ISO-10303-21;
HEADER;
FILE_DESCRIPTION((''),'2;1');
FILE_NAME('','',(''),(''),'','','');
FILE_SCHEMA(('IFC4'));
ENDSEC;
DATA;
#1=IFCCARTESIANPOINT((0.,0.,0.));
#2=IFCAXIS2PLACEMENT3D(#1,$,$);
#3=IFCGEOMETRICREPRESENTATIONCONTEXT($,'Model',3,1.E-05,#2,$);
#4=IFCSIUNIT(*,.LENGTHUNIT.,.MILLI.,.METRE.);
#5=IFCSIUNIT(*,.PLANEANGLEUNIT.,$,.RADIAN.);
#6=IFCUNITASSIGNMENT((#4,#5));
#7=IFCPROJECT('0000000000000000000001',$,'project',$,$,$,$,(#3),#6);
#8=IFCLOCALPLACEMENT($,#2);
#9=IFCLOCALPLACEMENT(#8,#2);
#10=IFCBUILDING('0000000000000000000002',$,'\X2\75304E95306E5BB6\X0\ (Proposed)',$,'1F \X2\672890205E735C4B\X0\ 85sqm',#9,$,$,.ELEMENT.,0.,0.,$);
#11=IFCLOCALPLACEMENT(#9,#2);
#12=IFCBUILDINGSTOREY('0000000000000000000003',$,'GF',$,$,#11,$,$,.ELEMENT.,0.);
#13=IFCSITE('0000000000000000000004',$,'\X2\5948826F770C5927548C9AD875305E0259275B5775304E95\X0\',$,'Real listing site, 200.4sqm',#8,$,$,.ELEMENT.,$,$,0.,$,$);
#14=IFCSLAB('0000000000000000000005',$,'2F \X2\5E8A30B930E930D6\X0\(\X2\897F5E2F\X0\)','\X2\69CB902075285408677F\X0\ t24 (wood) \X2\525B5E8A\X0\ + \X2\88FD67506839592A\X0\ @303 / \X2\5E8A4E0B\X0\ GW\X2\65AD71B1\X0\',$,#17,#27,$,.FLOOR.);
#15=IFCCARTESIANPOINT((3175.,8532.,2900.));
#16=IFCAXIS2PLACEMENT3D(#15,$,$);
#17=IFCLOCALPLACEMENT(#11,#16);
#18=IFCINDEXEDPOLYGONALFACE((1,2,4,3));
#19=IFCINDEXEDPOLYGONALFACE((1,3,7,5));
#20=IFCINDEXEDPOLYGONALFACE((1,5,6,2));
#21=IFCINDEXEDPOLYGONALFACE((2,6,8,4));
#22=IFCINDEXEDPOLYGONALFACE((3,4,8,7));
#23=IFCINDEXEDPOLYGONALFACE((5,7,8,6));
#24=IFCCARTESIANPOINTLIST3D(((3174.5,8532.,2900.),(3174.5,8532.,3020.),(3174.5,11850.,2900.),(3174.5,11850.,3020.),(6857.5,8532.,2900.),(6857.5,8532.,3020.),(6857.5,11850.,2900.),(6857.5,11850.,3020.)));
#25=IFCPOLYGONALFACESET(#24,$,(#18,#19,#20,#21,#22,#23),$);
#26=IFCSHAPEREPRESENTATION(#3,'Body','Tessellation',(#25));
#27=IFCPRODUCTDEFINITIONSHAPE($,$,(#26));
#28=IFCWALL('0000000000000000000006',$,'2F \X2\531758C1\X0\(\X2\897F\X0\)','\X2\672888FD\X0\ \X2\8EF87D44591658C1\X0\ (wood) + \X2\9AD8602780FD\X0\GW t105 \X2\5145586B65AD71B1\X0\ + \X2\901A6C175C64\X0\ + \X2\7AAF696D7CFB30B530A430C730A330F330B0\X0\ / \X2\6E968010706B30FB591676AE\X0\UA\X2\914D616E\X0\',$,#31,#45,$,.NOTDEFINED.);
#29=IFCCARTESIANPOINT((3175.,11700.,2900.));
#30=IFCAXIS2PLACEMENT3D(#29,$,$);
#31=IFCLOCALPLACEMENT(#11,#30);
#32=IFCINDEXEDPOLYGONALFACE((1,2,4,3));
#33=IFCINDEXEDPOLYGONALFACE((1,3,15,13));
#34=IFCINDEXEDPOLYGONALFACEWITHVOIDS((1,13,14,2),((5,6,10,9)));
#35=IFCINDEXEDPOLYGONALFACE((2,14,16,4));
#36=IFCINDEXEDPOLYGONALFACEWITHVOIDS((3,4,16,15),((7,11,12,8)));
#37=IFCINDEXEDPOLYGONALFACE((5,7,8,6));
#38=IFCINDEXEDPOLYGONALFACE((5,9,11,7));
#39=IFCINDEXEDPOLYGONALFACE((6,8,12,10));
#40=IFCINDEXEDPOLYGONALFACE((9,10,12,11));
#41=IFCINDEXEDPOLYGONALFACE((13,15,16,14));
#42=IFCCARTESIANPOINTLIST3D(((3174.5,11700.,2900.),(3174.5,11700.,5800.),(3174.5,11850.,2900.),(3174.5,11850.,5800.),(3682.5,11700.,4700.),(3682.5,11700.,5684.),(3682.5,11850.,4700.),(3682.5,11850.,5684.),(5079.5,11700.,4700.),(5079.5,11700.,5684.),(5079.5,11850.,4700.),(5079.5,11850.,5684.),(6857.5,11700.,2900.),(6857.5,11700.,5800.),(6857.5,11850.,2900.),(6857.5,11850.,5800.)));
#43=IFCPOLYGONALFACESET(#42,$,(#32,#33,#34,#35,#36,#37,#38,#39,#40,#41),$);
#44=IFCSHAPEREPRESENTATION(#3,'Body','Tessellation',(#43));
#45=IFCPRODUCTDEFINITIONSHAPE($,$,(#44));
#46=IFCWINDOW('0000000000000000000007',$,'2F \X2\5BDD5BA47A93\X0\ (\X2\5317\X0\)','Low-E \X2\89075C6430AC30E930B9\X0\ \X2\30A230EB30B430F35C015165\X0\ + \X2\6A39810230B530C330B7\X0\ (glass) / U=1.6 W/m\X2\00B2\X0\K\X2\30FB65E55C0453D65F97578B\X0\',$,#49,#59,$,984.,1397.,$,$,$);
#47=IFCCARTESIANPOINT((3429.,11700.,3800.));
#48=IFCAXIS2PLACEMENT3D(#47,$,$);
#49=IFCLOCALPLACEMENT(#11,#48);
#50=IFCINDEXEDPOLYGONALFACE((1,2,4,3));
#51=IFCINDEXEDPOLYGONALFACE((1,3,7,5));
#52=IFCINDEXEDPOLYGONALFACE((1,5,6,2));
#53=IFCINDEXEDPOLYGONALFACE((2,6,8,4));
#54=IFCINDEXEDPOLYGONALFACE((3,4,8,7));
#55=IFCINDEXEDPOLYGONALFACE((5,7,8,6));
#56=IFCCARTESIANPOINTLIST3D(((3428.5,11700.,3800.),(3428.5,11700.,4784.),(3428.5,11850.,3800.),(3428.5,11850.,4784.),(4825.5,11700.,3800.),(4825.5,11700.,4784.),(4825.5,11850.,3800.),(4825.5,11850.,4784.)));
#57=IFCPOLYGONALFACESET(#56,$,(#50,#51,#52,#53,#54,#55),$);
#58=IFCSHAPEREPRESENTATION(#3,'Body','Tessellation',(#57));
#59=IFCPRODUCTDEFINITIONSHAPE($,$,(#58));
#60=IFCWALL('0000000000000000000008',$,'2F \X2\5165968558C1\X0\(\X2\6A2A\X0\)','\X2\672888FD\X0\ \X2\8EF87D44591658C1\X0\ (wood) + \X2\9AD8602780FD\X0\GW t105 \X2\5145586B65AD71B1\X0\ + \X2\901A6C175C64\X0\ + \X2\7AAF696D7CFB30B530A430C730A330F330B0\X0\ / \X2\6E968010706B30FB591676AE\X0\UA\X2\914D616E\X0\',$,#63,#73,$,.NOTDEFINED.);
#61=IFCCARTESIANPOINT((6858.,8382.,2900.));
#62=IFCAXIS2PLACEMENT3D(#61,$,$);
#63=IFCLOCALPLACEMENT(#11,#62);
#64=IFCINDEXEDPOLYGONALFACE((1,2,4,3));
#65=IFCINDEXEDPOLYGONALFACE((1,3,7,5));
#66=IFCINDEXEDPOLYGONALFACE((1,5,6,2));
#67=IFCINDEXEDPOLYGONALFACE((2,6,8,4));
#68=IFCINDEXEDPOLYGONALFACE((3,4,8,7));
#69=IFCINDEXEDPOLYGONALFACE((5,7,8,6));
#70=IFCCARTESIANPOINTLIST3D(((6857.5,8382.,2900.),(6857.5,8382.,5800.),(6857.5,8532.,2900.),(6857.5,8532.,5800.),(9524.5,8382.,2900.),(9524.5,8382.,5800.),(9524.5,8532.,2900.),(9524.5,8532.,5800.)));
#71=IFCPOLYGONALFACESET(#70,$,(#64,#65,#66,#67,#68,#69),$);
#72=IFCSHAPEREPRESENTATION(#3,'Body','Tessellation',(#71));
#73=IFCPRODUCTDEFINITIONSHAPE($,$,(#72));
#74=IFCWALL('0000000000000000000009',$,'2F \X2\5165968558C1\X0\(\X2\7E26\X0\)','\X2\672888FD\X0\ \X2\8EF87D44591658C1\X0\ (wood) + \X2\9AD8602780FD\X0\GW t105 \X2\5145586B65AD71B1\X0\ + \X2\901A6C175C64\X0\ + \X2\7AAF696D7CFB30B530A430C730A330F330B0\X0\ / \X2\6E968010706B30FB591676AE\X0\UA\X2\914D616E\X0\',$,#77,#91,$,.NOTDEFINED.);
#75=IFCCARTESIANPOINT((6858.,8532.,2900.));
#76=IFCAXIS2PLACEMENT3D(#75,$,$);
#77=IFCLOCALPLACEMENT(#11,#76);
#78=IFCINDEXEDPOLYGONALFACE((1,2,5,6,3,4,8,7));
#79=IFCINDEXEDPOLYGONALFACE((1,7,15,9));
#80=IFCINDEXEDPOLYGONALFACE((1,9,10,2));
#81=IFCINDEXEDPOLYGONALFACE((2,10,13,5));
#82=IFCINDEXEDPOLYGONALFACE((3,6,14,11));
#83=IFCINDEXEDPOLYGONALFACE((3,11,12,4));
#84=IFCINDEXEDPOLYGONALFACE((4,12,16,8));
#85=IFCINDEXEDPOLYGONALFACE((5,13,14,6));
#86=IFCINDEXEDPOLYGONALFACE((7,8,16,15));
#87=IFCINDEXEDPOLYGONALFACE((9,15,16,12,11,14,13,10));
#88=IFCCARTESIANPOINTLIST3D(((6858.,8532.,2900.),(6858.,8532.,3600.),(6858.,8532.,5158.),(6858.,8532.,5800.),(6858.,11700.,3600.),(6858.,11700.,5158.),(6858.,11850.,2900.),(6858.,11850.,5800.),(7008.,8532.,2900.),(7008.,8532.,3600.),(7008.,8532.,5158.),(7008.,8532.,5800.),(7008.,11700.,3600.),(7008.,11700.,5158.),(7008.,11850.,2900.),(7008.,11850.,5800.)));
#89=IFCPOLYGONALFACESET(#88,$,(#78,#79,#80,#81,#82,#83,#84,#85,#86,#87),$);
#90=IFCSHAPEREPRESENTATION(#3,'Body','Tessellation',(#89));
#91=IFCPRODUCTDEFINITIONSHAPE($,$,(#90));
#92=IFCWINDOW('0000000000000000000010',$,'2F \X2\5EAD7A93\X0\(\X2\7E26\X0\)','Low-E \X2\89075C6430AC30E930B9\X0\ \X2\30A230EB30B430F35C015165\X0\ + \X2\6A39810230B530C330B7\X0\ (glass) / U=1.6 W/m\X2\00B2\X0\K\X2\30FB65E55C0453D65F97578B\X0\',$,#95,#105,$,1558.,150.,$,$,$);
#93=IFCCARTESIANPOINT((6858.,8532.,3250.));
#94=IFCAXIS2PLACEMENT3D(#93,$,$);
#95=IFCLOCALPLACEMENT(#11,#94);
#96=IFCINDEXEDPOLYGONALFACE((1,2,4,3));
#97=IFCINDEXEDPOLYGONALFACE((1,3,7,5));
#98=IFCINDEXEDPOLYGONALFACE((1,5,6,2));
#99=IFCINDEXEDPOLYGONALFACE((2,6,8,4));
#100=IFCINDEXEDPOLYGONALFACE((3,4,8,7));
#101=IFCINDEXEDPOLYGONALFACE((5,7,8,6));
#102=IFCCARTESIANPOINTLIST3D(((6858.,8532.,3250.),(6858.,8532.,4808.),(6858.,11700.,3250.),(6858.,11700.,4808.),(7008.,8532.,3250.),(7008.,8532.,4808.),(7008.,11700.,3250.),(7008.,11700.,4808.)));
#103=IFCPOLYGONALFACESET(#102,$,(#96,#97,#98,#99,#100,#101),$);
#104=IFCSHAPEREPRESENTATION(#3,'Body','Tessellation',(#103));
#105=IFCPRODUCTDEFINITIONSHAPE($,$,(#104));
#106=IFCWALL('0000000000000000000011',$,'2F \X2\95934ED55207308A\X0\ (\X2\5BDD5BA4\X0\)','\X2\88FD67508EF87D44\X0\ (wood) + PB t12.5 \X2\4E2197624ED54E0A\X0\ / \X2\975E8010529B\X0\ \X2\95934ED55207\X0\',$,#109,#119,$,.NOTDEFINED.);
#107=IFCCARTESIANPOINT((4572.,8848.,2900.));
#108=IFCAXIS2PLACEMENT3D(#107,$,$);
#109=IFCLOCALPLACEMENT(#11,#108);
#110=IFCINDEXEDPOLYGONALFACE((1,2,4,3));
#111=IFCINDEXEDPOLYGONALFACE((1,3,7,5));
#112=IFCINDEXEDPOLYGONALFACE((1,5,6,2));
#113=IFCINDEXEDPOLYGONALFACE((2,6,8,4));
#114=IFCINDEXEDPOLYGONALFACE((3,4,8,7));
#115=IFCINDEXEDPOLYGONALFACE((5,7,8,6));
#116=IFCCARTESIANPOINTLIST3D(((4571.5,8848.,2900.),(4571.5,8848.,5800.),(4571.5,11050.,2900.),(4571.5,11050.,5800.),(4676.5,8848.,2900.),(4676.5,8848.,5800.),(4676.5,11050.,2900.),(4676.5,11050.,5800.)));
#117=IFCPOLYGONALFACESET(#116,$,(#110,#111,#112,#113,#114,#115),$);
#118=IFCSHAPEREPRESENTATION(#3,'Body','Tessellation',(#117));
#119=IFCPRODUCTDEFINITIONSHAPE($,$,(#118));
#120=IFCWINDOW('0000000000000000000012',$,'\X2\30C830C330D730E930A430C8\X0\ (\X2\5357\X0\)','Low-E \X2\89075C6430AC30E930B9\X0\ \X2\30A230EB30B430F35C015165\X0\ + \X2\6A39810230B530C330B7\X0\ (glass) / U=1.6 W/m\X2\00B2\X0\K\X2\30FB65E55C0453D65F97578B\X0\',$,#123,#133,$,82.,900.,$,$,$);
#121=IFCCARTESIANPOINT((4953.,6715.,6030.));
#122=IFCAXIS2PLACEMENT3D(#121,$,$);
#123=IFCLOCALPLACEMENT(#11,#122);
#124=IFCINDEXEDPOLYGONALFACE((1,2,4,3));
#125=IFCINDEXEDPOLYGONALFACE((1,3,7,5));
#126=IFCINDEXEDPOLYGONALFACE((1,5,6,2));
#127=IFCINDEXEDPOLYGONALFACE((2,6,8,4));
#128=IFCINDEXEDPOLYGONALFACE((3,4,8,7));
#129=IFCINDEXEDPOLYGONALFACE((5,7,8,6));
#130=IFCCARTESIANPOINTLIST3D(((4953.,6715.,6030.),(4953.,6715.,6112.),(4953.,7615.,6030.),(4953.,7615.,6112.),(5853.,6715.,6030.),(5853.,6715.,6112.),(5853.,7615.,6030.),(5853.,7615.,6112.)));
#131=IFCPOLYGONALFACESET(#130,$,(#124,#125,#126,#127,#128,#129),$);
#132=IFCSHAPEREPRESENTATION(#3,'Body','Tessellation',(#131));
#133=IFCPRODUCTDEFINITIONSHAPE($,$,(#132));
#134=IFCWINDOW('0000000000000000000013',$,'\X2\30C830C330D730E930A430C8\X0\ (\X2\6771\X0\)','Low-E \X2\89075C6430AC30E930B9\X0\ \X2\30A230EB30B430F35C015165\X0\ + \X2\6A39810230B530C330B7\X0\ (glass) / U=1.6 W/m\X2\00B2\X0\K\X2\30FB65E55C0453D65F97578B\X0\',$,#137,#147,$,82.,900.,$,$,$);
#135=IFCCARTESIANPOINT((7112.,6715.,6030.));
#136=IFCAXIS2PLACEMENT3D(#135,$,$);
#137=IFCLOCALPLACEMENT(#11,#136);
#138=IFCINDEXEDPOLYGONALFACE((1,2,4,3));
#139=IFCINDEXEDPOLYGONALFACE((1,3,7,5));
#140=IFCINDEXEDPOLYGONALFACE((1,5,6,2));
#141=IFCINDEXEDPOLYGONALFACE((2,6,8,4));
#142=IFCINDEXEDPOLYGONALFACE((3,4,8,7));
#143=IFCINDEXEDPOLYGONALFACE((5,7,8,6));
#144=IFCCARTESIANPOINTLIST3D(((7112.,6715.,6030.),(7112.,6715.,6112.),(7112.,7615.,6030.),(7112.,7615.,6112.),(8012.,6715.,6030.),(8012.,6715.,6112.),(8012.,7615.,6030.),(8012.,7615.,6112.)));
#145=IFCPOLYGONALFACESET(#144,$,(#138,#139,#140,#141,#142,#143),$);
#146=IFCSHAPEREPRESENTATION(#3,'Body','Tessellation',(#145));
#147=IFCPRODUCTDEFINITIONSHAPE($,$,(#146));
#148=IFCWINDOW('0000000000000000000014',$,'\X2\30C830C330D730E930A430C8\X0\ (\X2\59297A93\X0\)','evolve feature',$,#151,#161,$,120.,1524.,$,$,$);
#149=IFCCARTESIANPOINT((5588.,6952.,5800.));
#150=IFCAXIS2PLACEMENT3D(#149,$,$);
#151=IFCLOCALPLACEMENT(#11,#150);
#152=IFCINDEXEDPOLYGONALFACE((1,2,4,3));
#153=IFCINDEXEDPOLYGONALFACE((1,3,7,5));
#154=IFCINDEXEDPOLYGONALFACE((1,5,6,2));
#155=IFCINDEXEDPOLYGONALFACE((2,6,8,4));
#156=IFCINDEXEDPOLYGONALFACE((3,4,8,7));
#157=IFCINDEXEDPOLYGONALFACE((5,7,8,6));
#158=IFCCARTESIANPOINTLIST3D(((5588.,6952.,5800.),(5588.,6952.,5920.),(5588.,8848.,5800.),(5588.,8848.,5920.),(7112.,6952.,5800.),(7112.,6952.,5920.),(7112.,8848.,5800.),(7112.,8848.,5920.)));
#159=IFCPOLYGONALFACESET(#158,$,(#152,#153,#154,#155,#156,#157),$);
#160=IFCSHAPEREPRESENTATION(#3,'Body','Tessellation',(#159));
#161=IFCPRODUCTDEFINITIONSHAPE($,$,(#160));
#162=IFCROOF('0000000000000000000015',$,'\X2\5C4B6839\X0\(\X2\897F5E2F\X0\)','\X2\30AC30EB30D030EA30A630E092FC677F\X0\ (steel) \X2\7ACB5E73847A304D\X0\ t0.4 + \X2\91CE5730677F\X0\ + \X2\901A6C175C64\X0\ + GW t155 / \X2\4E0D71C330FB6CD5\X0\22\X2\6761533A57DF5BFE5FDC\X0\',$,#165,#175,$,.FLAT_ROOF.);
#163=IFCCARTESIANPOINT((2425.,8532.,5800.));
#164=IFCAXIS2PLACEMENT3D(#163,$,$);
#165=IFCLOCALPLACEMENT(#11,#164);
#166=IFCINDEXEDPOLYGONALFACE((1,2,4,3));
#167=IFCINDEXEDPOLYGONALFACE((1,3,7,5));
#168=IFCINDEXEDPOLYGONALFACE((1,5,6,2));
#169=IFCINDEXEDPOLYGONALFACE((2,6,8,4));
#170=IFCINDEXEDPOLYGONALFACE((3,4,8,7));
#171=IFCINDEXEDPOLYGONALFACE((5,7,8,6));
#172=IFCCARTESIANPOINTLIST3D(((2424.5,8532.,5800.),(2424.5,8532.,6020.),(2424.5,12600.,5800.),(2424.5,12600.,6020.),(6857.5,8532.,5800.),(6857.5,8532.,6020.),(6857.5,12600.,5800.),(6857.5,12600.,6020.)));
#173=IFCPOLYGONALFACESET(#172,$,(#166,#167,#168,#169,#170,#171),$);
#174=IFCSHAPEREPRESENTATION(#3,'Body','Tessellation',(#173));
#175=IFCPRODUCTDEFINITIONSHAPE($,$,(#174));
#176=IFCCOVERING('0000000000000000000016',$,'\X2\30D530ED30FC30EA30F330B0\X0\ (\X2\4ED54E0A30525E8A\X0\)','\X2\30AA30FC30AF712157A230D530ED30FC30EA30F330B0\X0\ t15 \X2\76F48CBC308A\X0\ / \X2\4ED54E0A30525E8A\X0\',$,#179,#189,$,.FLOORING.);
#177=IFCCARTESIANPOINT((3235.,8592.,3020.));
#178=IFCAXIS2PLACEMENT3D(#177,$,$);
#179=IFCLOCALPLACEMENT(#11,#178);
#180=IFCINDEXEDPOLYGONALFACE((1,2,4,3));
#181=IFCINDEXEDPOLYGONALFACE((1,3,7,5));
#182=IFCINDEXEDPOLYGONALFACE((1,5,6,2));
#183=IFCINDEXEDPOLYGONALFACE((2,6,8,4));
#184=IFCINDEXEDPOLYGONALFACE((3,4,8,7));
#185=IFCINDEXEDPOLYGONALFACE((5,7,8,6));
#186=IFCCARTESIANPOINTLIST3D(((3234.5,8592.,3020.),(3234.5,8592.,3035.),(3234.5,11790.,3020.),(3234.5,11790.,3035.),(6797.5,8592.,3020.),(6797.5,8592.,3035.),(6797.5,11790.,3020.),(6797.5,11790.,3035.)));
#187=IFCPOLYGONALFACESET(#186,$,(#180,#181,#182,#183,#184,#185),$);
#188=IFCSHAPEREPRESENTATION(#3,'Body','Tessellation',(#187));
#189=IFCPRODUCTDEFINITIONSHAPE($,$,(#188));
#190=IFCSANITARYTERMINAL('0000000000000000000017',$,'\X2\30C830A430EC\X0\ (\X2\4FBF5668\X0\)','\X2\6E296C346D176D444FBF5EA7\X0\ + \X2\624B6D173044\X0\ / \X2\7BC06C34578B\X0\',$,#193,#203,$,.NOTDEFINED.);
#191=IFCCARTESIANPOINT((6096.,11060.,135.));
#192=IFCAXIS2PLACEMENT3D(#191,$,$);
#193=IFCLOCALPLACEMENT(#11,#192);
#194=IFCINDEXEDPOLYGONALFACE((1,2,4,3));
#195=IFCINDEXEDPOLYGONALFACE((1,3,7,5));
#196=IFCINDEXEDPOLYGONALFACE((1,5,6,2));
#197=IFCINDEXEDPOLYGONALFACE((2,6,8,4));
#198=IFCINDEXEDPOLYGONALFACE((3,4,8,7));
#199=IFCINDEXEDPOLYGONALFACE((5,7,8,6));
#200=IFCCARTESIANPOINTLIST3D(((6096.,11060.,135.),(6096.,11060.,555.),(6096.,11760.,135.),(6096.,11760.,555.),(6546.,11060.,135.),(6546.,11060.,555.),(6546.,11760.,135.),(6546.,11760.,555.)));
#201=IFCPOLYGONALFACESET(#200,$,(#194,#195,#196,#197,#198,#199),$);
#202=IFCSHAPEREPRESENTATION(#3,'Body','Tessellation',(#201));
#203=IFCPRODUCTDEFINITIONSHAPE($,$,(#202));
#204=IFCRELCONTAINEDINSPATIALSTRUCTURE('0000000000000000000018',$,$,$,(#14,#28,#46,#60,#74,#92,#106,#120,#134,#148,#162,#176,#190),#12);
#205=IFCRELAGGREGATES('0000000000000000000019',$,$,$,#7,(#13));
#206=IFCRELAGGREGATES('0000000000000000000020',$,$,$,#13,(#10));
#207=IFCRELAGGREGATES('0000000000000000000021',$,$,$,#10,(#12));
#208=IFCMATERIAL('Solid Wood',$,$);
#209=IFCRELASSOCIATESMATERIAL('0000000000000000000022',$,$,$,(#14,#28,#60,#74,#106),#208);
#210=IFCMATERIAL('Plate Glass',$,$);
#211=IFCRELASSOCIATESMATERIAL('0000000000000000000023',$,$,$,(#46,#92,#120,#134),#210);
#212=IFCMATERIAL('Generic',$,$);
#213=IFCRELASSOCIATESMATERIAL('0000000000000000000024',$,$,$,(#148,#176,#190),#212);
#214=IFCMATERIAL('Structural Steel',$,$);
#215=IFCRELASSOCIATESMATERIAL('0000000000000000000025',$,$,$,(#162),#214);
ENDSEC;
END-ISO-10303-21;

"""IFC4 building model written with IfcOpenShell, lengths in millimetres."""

from ifc_helpers import new_model, si_unit, frame, frame_2d, origin, place, context, project, spatial, rectangle, extrude, material, element, fill, save


model = new_model("IFC4")

# Units and contexts
model_context = context("Model", 3, precision=1e-05, world=origin())
ifc_project = project(units=[si_unit("LENGTHUNIT", "METRE", prefix="MILLI"), si_unit("PLANEANGLEUNIT", "RADIAN")], contexts=[model_context])

# Site, building, storey
site_placement = place(None, origin())
site = spatial("IfcSite", under=ifc_project, at=site_placement, Name="奈良県大和高田市大字田井", ObjectType="Real listing site, 200.4sqm", CompositionType="ELEMENT", RefElevation=0.0)
building_placement = place(site_placement, origin())
building = spatial("IfcBuilding", under=site, at=building_placement, Name="田井の家 (Proposed)", ObjectType="1F 木造平屋 85sqm", CompositionType="ELEMENT", ElevationOfRefHeight=0.0, ElevationOfTerrain=0.0)
storey_placement = place(building_placement, origin())
storey = spatial("IfcBuildingStorey", under=building, at=storey_placement, Name="GF", CompositionType="ELEMENT", Elevation=0.0)

# Slab
ifc_material_1 = material(Name="Solid Wood")
slab_placement = place(storey_placement, frame((3175.0, 8532.0, 2900.0)))
element("IfcSlab", 1, at=slab_placement, inside=storey, material=ifc_material_1, Name="2F 床スラブ(西帯)", Description="構造用合板 t24 (wood) 剛床 + 製材根太 @303 / 床下 GW断熱", PredefinedType="FLOOR", context=model_context, shape_type="SweptSolid", body=[
    extrude(rectangle(XDim=3683.0, YDim=3318.0, at=frame_2d((1841.0, 1659.0))), frame((3175.0, 8532.0, 2900.0)), (0.0, 0.0, 1.0), 120.0),
])

# Wall, opening, window
wall_1_placement = place(storey_placement, frame((3175.0, 11700.0, 2900.0)))
wall_1 = element("IfcWall", 2, at=wall_1_placement, inside=storey, material=ifc_material_1, Name="2F 北壁(西)", Description="木製 軸組外壁 (wood) + 高性能GW t105 充填断熱 + 通気層 + 窯業系サイディング / 準耐火・外皮UA配慮", PredefinedType="NOTDEFINED", context=model_context, shape_type="SweptSolid", body=[
    extrude(rectangle(XDim=3683.0, YDim=150.0, at=frame_2d((1841.0, 75.0))), frame((3175.0, 11700.0, 2900.0)), (0.0, 0.0, 1.0), 2900.0),
])
opening_1_placement = place(storey_placement, frame((3429.0, 11700.0, 3800.0)))
opening_1 = element("IfcOpeningElement", 3, at=opening_1_placement, cuts=wall_1, PredefinedType="NOTDEFINED", context=model_context, shape_type="SweptSolid", body=[
    extrude(rectangle(XDim=1397.0, YDim=150.0, at=frame_2d((698.0, 75.0))), frame((3429.0, 11700.0, 3800.0)), (0.0, 0.0, 1.0), 984.0),
])
ifc_material_2 = material(Name="Plate Glass")
window_1_placement = place(storey_placement, frame((3429.0, 11700.0, 3800.0)))
window_1 = element("IfcWindow", 4, at=window_1_placement, inside=storey, material=ifc_material_2, Name="2F 寝室窓 (北)", Description="Low-E 複層ガラス アルゴン封入 + 樹脂サッシ (glass) / U=1.6 W/m²K・日射取得型", OverallHeight=984.0, OverallWidth=1397.0, context=model_context, shape_type="SweptSolid", body=[
    extrude(rectangle(XDim=1397.0, YDim=150.0, at=frame_2d((698.0, 75.0))), frame((3429.0, 11700.0, 3800.0)), (0.0, 0.0, 1.0), 984.0),
])
fill(opening_1, window_1)

# Wall
wall_2_placement = place(storey_placement, frame((6858.0, 8382.0, 2900.0)))
element("IfcWall", 5, at=wall_2_placement, inside=storey, material=ifc_material_1, Name="2F 入隅壁(横)", Description="木製 軸組外壁 (wood) + 高性能GW t105 充填断熱 + 通気層 + 窯業系サイディング / 準耐火・外皮UA配慮", PredefinedType="NOTDEFINED", context=model_context, shape_type="SweptSolid", body=[
    extrude(rectangle(XDim=2667.0, YDim=150.0, at=frame_2d((1333.0, 75.0))), frame((6858.0, 8382.0, 2900.0)), (0.0, 0.0, 1.0), 2900.0),
])

# Wall, opening, window
wall_3_placement = place(storey_placement, frame((6858.0, 8532.0, 2900.0)))
wall_3 = element("IfcWall", 6, at=wall_3_placement, inside=storey, material=ifc_material_1, Name="2F 入隅壁(縦)", Description="木製 軸組外壁 (wood) + 高性能GW t105 充填断熱 + 通気層 + 窯業系サイディング / 準耐火・外皮UA配慮", PredefinedType="NOTDEFINED", context=model_context, shape_type="SweptSolid", body=[
    extrude(rectangle(XDim=150.0, YDim=3318.0, at=frame_2d((75.0, 1659.0))), frame((6858.0, 8532.0, 2900.0)), (0.0, 0.0, 1.0), 2900.0),
])
opening_2_placement = place(storey_placement, frame((6858.0, 8532.0, 3250.0)))
opening_2 = element("IfcOpeningElement", 7, at=opening_2_placement, cuts=wall_3, PredefinedType="NOTDEFINED", context=model_context, shape_type="SweptSolid", body=[
    extrude(rectangle(XDim=150.0, YDim=3168.0, at=frame_2d((75.0, 1584.0))), frame((6858.0, 8532.0, 3250.0)), (0.0, 0.0, 1.0), 1558.0),
])
window_2_placement = place(storey_placement, frame((6858.0, 8532.0, 3250.0)))
window_2 = element("IfcWindow", 8, at=window_2_placement, inside=storey, material=ifc_material_2, Name="2F 庭窓(縦)", Description="Low-E 複層ガラス アルゴン封入 + 樹脂サッシ (glass) / U=1.6 W/m²K・日射取得型", OverallHeight=1558.0, OverallWidth=150.0, context=model_context, shape_type="SweptSolid", body=[
    extrude(rectangle(XDim=150.0, YDim=3168.0, at=frame_2d((75.0, 1584.0))), frame((6858.0, 8532.0, 3250.0)), (0.0, 0.0, 1.0), 1558.0),
])
fill(opening_2, window_2)

# Wall
wall_4_placement = place(storey_placement, frame((4572.0, 8848.0, 2900.0)))
element("IfcWall", 9, at=wall_4_placement, inside=storey, material=ifc_material_1, Name="2F 間仕切り (寝室)", Description="製材軸組 (wood) + PB t12.5 両面仕上 / 非耐力 間仕切", PredefinedType="NOTDEFINED", context=model_context, shape_type="SweptSolid", body=[
    extrude(rectangle(XDim=105.0, YDim=2202.0, at=frame_2d((52.0, 1101.0))), frame((4572.0, 8848.0, 2900.0)), (0.0, 0.0, 1.0), 2900.0),
])

# Windows
window_3_placement = place(storey_placement, frame((4953.0, 6715.0, 6030.0)))
element("IfcWindow", 10, at=window_3_placement, inside=storey, material=ifc_material_2, Name="トップライト (南)", Description="Low-E 複層ガラス アルゴン封入 + 樹脂サッシ (glass) / U=1.6 W/m²K・日射取得型", OverallHeight=82.0, OverallWidth=900.0, context=model_context, shape_type="SweptSolid", body=[
    extrude(rectangle(XDim=900.0, YDim=900.0, at=frame_2d((450.0, 450.0))), frame((4953.0, 6715.0, 6030.0)), (0.0, 0.0, 1.0), 82.0),
])
window_4_placement = place(storey_placement, frame((7112.0, 6715.0, 6030.0)))
element("IfcWindow", 11, at=window_4_placement, inside=storey, material=ifc_material_2, Name="トップライト (東)", Description="Low-E 複層ガラス アルゴン封入 + 樹脂サッシ (glass) / U=1.6 W/m²K・日射取得型", OverallHeight=82.0, OverallWidth=900.0, context=model_context, shape_type="SweptSolid", body=[
    extrude(rectangle(XDim=900.0, YDim=900.0, at=frame_2d((450.0, 450.0))), frame((7112.0, 6715.0, 6030.0)), (0.0, 0.0, 1.0), 82.0),
])
ifc_material_3 = material(Name="Generic")
window_5_placement = place(storey_placement, frame((5588.0, 6952.0, 5800.0)))
element("IfcWindow", 12, at=window_5_placement, inside=storey, material=ifc_material_3, Name="トップライト (天窓)", Description="evolve feature", OverallHeight=120.0, OverallWidth=1524.0, context=model_context, shape_type="SweptSolid", body=[
    extrude(rectangle(XDim=1524.0, YDim=1896.0, at=frame_2d((762.0, 948.0))), frame((5588.0, 6952.0, 5800.0)), (0.0, 0.0, 1.0), 120.0),
])

# Roof
ifc_material_4 = material(Name="Structural Steel")
for number, where, name in (
    (13, (2425.0, 8532.0, 5800.0), "屋根(西帯)"),
):
    element("IfcRoof", number, at=place(storey_placement, frame(where)), inside=storey, material=ifc_material_4, Name=name, Description="ガルバリウム鋼板 (steel) 立平葺き t0.4 + 野地板 + 通気層 + GW t155 / 不燃・法22条区域対応", PredefinedType="FLAT_ROOF", context=model_context, shape_type="SweptSolid", body=[
        extrude(rectangle(XDim=4433.0, YDim=4068.0, at=frame_2d((2216.0, 2034.0))), frame((2425.0, 8532.0, 5800.0)), (0.0, 0.0, 1.0), 220.0),
    ])

# Covering
covering_placement = place(storey_placement, frame((3235.0, 8592.0, 3020.0)))
element("IfcCovering", 14, at=covering_placement, inside=storey, material=ifc_material_3, Name="フローリング (仕上げ床)", Description="オーク無垢フローリング t15 直貼り / 仕上げ床", PredefinedType="FLOORING", context=model_context, shape_type="SweptSolid", body=[
    extrude(rectangle(XDim=3563.0, YDim=3198.0, at=frame_2d((1781.0, 1599.0))), frame((3235.0, 8592.0, 3020.0)), (0.0, 0.0, 1.0), 15.0),
])

# Sanitary terminal
sanitary_terminal_placement = place(storey_placement, frame((6096.0, 11060.0, 135.0)))
element("IfcSanitaryTerminal", 15, at=sanitary_terminal_placement, inside=storey, material=ifc_material_3, Name="トイレ (便器)", Description="温水洗浄便座 + 手洗い / 節水型", PredefinedType="NOTDEFINED", context=model_context, shape_type="SweptSolid", body=[
    extrude(rectangle(XDim=450.0, YDim=700.0, at=frame_2d((225.0, 350.0))), frame((6096.0, 11060.0, 135.0)), (0.0, 0.0, 1.0), 420.0),
])

save(model, "model.ifc")
